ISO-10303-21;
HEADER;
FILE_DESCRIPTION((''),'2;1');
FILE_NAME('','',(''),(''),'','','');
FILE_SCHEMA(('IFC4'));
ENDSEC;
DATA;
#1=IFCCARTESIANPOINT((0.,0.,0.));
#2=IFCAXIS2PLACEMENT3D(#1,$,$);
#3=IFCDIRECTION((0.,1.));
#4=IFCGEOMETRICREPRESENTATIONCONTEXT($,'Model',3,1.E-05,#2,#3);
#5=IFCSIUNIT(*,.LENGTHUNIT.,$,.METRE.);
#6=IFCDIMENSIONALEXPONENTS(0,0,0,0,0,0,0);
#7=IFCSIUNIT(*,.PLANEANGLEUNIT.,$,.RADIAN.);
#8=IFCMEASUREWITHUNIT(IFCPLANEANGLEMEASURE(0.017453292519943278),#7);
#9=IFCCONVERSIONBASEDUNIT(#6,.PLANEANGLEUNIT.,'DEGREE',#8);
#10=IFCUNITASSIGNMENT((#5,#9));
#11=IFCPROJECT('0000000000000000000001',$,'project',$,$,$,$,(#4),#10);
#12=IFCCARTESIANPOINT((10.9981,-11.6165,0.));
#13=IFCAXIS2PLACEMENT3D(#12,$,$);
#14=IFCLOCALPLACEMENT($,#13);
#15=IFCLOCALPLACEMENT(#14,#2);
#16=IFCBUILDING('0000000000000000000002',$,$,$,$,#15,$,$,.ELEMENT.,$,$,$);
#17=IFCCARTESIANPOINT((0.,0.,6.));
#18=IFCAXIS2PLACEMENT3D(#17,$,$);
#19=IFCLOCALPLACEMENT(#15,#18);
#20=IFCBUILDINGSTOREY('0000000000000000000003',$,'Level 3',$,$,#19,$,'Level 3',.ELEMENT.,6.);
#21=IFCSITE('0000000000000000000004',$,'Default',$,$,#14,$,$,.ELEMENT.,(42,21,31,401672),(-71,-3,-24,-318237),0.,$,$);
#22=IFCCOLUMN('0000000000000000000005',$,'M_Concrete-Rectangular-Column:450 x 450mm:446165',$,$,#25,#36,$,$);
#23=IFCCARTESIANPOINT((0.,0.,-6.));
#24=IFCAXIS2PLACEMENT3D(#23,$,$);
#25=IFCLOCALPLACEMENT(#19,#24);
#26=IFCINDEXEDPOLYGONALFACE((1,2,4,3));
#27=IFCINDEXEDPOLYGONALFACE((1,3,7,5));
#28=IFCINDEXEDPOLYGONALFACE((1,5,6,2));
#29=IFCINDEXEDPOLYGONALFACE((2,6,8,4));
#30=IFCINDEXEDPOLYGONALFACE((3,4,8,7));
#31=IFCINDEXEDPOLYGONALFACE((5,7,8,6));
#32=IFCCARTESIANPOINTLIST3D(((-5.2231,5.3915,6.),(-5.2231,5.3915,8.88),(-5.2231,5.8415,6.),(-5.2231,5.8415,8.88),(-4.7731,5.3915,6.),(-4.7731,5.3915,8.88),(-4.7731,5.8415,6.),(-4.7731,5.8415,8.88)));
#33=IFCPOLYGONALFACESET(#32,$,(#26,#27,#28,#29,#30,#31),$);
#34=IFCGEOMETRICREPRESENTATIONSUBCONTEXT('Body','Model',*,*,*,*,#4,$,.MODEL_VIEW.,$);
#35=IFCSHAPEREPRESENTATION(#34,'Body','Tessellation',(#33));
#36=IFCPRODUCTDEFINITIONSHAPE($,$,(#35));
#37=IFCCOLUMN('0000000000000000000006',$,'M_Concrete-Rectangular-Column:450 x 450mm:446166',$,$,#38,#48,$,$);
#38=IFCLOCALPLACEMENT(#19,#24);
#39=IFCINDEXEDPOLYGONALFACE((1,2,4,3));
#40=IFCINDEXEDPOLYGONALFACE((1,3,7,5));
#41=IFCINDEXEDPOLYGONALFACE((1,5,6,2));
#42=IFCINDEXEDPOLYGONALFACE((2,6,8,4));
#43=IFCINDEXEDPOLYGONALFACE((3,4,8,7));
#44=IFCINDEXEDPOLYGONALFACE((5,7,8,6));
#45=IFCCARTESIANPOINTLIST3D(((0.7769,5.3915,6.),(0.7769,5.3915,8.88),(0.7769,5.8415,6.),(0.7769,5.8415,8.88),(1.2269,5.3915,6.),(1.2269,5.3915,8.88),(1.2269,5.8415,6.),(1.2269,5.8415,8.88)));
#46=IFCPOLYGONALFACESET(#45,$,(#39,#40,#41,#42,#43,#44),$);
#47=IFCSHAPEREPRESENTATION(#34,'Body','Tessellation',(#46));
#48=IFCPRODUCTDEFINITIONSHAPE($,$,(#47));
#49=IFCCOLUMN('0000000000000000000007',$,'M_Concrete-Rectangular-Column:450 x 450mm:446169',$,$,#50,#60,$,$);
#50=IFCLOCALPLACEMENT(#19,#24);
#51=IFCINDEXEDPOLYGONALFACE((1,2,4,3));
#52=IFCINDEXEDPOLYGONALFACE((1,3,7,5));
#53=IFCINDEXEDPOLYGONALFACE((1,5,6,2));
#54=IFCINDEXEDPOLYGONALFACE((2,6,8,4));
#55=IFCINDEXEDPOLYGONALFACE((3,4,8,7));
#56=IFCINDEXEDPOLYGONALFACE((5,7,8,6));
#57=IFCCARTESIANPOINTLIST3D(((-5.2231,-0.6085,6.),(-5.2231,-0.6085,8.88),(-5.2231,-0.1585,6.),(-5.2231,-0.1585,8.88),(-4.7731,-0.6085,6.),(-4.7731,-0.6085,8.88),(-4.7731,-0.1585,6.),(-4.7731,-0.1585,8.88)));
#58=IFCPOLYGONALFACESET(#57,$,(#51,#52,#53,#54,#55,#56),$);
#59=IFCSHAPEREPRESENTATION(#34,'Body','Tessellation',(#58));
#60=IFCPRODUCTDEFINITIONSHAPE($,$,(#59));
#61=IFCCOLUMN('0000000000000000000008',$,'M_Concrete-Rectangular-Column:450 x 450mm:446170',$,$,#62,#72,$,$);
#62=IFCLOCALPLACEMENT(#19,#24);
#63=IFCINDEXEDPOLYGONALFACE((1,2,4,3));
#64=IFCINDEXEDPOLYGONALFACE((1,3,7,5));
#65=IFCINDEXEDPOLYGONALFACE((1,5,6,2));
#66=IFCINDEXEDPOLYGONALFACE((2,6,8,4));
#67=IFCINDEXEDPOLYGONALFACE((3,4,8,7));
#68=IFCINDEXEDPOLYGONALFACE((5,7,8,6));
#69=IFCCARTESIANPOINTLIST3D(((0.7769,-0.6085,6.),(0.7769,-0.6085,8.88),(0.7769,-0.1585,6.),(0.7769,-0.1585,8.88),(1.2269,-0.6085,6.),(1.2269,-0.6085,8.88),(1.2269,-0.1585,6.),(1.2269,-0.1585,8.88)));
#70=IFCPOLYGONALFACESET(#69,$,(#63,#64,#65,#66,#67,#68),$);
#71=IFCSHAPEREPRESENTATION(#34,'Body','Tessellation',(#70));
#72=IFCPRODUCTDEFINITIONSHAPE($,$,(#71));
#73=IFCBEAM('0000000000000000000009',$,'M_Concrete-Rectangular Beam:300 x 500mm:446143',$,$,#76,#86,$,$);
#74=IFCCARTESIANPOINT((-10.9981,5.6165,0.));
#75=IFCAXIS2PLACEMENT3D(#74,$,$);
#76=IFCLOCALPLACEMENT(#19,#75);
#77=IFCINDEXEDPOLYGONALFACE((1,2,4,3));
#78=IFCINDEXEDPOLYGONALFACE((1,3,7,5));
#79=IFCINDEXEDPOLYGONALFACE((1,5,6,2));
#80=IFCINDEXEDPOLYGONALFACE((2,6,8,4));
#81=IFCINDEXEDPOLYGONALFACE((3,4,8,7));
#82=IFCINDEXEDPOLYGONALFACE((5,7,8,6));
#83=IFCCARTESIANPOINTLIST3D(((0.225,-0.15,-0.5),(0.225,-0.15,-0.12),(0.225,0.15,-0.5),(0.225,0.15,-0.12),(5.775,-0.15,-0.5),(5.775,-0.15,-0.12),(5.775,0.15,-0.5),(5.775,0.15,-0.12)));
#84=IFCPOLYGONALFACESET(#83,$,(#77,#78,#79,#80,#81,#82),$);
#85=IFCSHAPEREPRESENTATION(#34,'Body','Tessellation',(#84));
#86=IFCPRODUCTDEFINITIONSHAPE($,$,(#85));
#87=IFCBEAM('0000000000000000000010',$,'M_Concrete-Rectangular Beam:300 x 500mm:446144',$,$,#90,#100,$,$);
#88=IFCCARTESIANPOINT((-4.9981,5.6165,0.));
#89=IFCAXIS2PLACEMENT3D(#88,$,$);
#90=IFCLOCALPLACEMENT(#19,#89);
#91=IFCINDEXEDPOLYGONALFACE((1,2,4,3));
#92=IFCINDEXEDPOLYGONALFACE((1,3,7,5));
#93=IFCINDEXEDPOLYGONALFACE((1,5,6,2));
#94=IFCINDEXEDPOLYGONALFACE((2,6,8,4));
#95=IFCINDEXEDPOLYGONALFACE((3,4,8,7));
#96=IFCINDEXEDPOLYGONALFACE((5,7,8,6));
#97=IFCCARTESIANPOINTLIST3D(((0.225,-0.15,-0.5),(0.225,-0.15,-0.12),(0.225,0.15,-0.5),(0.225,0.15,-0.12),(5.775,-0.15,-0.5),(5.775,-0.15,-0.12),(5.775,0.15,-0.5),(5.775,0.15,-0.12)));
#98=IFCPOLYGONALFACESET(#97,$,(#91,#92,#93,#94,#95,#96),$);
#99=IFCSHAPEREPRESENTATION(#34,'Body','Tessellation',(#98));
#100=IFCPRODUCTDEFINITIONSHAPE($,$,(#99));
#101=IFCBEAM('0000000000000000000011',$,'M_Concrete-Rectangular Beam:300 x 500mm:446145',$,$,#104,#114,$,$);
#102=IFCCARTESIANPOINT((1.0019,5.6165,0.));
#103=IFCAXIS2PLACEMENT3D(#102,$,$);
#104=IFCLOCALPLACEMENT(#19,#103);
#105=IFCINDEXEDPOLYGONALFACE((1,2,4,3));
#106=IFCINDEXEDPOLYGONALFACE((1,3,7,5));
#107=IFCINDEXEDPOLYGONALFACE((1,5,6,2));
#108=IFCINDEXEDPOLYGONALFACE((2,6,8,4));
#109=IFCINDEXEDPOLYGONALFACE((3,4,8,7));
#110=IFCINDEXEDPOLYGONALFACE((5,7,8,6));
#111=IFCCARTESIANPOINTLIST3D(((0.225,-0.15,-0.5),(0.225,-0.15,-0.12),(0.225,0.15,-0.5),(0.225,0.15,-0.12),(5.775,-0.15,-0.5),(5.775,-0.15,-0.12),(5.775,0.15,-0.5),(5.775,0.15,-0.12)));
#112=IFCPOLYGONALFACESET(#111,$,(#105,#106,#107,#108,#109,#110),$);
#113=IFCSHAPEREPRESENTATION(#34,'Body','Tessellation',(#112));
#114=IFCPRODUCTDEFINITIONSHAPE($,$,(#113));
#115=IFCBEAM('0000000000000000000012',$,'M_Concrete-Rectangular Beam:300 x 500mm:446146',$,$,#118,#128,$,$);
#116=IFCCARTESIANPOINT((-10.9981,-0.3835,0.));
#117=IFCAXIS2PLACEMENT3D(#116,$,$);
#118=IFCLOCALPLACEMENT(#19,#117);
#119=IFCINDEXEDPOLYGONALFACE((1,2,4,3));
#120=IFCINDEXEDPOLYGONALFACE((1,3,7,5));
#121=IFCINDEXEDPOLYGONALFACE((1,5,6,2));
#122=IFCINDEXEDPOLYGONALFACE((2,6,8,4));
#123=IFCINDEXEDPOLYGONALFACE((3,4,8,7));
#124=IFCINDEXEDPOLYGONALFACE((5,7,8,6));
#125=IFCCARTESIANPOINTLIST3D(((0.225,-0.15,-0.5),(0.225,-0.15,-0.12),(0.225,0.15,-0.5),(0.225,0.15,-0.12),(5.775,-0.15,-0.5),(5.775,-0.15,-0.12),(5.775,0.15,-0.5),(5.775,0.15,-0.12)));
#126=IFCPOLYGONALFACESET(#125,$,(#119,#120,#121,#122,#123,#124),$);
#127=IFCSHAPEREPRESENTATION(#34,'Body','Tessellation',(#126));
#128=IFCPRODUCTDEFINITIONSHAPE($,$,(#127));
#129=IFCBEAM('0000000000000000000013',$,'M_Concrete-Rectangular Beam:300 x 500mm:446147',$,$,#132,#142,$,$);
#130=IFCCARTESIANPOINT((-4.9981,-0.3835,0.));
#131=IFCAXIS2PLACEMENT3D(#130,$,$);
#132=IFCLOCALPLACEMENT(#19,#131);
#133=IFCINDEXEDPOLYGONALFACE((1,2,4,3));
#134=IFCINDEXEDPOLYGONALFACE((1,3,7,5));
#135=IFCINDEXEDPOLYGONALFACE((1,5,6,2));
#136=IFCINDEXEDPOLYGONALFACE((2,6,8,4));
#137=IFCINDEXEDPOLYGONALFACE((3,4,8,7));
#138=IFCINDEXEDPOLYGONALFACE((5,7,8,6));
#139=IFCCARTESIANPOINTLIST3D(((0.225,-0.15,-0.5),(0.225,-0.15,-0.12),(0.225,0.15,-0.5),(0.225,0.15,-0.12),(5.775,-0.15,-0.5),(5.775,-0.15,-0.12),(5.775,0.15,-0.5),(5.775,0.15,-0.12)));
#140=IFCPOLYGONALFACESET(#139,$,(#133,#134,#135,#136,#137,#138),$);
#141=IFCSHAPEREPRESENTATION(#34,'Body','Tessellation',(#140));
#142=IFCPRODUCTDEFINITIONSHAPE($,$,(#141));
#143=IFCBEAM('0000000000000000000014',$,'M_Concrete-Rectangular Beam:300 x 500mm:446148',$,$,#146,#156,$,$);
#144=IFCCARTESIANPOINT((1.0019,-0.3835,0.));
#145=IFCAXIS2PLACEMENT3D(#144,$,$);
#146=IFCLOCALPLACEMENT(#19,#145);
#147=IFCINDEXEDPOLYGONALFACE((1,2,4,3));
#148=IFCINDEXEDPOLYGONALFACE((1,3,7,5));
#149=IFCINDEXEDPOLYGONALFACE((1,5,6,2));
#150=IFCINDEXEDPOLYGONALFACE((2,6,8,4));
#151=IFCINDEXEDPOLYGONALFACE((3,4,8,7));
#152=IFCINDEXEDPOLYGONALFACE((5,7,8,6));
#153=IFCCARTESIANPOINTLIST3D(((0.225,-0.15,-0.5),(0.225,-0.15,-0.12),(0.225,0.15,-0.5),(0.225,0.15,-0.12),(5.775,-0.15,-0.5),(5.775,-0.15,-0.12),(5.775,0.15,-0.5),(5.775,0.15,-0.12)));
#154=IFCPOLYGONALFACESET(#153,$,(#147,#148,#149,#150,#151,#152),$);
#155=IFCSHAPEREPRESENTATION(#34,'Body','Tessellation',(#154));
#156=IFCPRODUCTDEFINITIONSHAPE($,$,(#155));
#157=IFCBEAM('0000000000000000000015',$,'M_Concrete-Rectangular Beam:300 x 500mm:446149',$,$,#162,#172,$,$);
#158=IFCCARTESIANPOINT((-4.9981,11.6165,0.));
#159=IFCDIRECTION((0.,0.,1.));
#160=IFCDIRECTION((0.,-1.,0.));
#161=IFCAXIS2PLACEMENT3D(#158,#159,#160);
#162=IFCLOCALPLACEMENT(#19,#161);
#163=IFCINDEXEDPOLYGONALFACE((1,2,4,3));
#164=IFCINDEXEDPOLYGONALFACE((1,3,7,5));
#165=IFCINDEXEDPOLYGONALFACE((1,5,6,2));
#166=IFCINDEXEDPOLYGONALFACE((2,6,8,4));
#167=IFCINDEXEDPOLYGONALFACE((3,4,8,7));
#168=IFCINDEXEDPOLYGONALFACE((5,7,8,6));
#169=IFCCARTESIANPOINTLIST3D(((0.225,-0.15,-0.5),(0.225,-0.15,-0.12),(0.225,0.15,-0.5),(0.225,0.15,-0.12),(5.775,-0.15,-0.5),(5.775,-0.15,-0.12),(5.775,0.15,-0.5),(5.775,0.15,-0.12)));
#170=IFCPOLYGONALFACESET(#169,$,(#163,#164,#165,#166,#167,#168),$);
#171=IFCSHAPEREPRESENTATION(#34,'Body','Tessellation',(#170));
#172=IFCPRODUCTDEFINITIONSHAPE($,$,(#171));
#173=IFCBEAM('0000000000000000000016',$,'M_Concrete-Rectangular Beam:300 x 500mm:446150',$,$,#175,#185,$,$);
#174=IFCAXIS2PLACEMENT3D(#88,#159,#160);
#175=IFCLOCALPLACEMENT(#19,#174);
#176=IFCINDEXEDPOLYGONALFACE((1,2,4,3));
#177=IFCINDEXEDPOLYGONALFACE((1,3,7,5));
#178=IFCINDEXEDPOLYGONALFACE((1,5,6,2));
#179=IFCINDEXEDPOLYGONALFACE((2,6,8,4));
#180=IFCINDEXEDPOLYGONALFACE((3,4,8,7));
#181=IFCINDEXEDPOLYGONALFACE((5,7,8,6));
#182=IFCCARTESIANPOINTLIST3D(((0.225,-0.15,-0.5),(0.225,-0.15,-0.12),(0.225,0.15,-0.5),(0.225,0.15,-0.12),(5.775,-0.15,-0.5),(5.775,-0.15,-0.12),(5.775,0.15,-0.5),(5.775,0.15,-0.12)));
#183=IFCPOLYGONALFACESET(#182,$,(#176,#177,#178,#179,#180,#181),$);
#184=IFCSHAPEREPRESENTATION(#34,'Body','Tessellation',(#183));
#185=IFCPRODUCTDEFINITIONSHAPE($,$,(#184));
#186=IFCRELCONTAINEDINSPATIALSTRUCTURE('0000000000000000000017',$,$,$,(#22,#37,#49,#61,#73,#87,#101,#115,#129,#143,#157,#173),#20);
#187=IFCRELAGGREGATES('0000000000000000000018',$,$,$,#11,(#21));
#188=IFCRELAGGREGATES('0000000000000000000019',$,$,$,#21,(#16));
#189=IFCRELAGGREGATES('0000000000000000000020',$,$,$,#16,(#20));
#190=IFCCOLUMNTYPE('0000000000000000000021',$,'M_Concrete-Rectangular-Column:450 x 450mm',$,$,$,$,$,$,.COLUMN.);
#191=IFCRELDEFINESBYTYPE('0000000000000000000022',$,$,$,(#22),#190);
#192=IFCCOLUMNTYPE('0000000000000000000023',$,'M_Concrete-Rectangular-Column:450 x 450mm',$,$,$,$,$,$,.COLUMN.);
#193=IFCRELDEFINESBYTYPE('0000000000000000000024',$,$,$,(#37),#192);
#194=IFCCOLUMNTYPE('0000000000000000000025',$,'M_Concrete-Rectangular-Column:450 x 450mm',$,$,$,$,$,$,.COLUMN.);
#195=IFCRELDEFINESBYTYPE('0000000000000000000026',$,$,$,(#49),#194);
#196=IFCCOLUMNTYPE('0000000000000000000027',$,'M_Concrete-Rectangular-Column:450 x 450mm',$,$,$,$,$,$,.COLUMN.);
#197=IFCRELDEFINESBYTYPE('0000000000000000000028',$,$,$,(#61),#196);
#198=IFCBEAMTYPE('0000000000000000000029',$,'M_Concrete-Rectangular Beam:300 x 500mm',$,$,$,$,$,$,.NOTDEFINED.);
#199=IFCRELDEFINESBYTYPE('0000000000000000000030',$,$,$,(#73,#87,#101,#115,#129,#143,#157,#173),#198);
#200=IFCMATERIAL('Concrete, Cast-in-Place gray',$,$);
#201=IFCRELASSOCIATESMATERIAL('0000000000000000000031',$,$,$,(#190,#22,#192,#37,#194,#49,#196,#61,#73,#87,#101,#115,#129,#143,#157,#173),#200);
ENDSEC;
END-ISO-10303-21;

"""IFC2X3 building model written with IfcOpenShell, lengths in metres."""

from ifc_helpers import new_model, entity, si_unit, converted_unit, direction, frame, frame_2d, origin, place, context, subcontext, project, spatial, rectangle, extrude, source, transform, mapped, material, type_object, type_shapes, element, save


model = new_model("IFC2X3")

# Units and contexts
model_context = context("Model", 3, precision=1e-05, world=origin(), true_north=direction((0.0, 1.0)))
body_context = subcontext(model_context, "Body", "Model", "MODEL_VIEW")
ifc_project = project(units=[si_unit("LENGTHUNIT", "METRE"), converted_unit("PLANEANGLEUNIT", "DEGREE", entity("IfcPlaneAngleMeasure", 0.017453292519943278), si_unit("PLANEANGLEUNIT", "RADIAN"), dimensions=[0, 0, 0, 0, 0, 0, 0])], contexts=[model_context])

# Site, building, storey
site_placement = place(None, frame((10.9981, -11.6165, 0.0)))
site = spatial("IfcSite", under=ifc_project, at=site_placement, Name="Default", CompositionType="ELEMENT", RefLatitude=(42, 21, 31, 401672), RefLongitude=(-71, -3, -24, -318237), RefElevation=0.0)
building_placement = place(site_placement, origin())
building = spatial("IfcBuilding", under=site, at=building_placement, CompositionType="ELEMENT")
storey_placement = place(building_placement, frame((0.0, 0.0, 6.0)))
storey = spatial("IfcBuildingStorey", under=building, at=storey_placement, Name="Level 3", LongName="Level 3", CompositionType="ELEMENT", Elevation=6.0)

# Columns
ifc_material_1 = material(Name="Concrete, Cast-in-Place gray")
column_type_1 = type_object("IfcColumnType", Name="M_Concrete-Rectangular-Column:450 x 450mm", PredefinedType="COLUMN", material=ifc_material_1)
shared_shape_1 = source(origin(), body_context, "Body", "SweptSolid", [
    extrude(rectangle(XDim=0.45, YDim=0.45, at=frame_2d((0.0, 0.0), x_axis=(1.0, 0.0))), frame((-4.9981, 5.6165, 6.0), z_axis=(0.0, 0.0, 1.0), x_axis=(-1.0, 0.0, 0.0)), (0.0, 0.0, 1.0), 2.88),
])
type_shapes(column_type_1, [shared_shape_1])
column_1_placement = place(storey_placement, frame((0.0, 0.0, -6.0)))
element("IfcColumn", 1, at=column_1_placement, inside=storey, type_object=column_type_1, material=ifc_material_1, Name="M_Concrete-Rectangular-Column:450 x 450mm:446165", context=body_context, shape_type="MappedRepresentation", body=[
    mapped(shared_shape_1, transform((0.0, 0.0, 0.0), scale=1.0)),
])
column_type_2 = type_object("IfcColumnType", Name="M_Concrete-Rectangular-Column:450 x 450mm", PredefinedType="COLUMN", material=ifc_material_1)
shared_shape_2 = source(origin(), body_context, "Body", "SweptSolid", [
    extrude(rectangle(XDim=0.45, YDim=0.45, at=frame_2d((0.0, 0.0), x_axis=(1.0, 0.0))), frame((1.0019, 5.6165, 6.0), z_axis=(0.0, 0.0, 1.0), x_axis=(-1.0, 0.0, 0.0)), (0.0, 0.0, 1.0), 2.88),
])
type_shapes(column_type_2, [shared_shape_2])
column_2_placement = place(storey_placement, frame((0.0, 0.0, -6.0)))
element("IfcColumn", 2, at=column_2_placement, inside=storey, type_object=column_type_2, material=ifc_material_1, Name="M_Concrete-Rectangular-Column:450 x 450mm:446166", context=body_context, shape_type="MappedRepresentation", body=[
    mapped(shared_shape_2, transform((0.0, 0.0, 0.0), scale=1.0)),
])
column_type_3 = type_object("IfcColumnType", Name="M_Concrete-Rectangular-Column:450 x 450mm", PredefinedType="COLUMN", material=ifc_material_1)
shared_shape_3 = source(origin(), body_context, "Body", "SweptSolid", [
    extrude(rectangle(XDim=0.45, YDim=0.45, at=frame_2d((0.0, 0.0), x_axis=(1.0, 0.0))), frame((-4.9981, -0.3835, 6.0), z_axis=(0.0, 0.0, 1.0), x_axis=(-1.0, 0.0, 0.0)), (0.0, 0.0, 1.0), 2.88),
])
type_shapes(column_type_3, [shared_shape_3])
column_3_placement = place(storey_placement, frame((0.0, 0.0, -6.0)))
element("IfcColumn", 3, at=column_3_placement, inside=storey, type_object=column_type_3, material=ifc_material_1, Name="M_Concrete-Rectangular-Column:450 x 450mm:446169", context=body_context, shape_type="MappedRepresentation", body=[
    mapped(shared_shape_3, transform((0.0, 0.0, 0.0), scale=1.0)),
])
column_type_4 = type_object("IfcColumnType", Name="M_Concrete-Rectangular-Column:450 x 450mm", PredefinedType="COLUMN", material=ifc_material_1)
shared_shape_4 = source(origin(), body_context, "Body", "SweptSolid", [
    extrude(rectangle(XDim=0.45, YDim=0.45, at=frame_2d((0.0, 0.0), x_axis=(1.0, 0.0))), frame((1.0019, -0.3835, 6.0), z_axis=(0.0, 0.0, 1.0), x_axis=(-1.0, 0.0, 0.0)), (0.0, 0.0, 1.0), 2.88),
])
type_shapes(column_type_4, [shared_shape_4])
column_4_placement = place(storey_placement, frame((0.0, 0.0, -6.0)))
element("IfcColumn", 4, at=column_4_placement, inside=storey, type_object=column_type_4, material=ifc_material_1, Name="M_Concrete-Rectangular-Column:450 x 450mm:446170", context=body_context, shape_type="MappedRepresentation", body=[
    mapped(shared_shape_4, transform((0.0, 0.0, 0.0), scale=1.0)),
])

# Beams
beam_type = type_object("IfcBeamType", Name="M_Concrete-Rectangular Beam:300 x 500mm", PredefinedType="NOTDEFINED")
beam_1_placement = place(storey_placement, frame((-10.9981, 5.6165, 0.0)))
element("IfcBeam", 5, at=beam_1_placement, inside=storey, type_object=beam_type, material=ifc_material_1, Name="M_Concrete-Rectangular Beam:300 x 500mm:446143", context=body_context, shape_type="SweptSolid", body=[
    extrude(rectangle(XDim=0.38, YDim=0.3, at=frame_2d((0.0, 0.0), x_axis=(1.0, 0.0))), frame((0.225, 0.0, -0.31), z_axis=(1.0, 0.0, 0.0), x_axis=(0.0, 0.0, -1.0)), (0.0, 0.0, 1.0), 5.55),
])
beam_2_placement = place(storey_placement, frame((-4.9981, 5.6165, 0.0)))
element("IfcBeam", 6, at=beam_2_placement, inside=storey, type_object=beam_type, material=ifc_material_1, Name="M_Concrete-Rectangular Beam:300 x 500mm:446144", context=body_context, shape_type="SweptSolid", body=[
    extrude(rectangle(XDim=0.38, YDim=0.3, at=frame_2d((0.0, 0.0), x_axis=(1.0, 0.0))), frame((0.225, 0.0, -0.31), z_axis=(1.0, 0.0, 0.0), x_axis=(0.0, 0.0, -1.0)), (0.0, 0.0, 1.0), 5.55),
])
beam_3_placement = place(storey_placement, frame((1.0019, 5.6165, 0.0)))
element("IfcBeam", 7, at=beam_3_placement, inside=storey, type_object=beam_type, material=ifc_material_1, Name="M_Concrete-Rectangular Beam:300 x 500mm:446145", context=body_context, shape_type="SweptSolid", body=[
    extrude(rectangle(XDim=0.38, YDim=0.3, at=frame_2d((0.0, 0.0), x_axis=(1.0, 0.0))), frame((0.225, 0.0, -0.31), z_axis=(1.0, 0.0, 0.0), x_axis=(0.0, 0.0, -1.0)), (0.0, 0.0, 1.0), 5.55),
])
beam_4_placement = place(storey_placement, frame((-10.9981, -0.3835, 0.0)))
element("IfcBeam", 8, at=beam_4_placement, inside=storey, type_object=beam_type, material=ifc_material_1, Name="M_Concrete-Rectangular Beam:300 x 500mm:446146", context=body_context, shape_type="SweptSolid", body=[
    extrude(rectangle(XDim=0.38, YDim=0.3, at=frame_2d((0.0, 0.0), x_axis=(1.0, 0.0))), frame((0.225, 0.0, -0.31), z_axis=(1.0, 0.0, 0.0), x_axis=(0.0, 0.0, -1.0)), (0.0, 0.0, 1.0), 5.55),
])
beam_5_placement = place(storey_placement, frame((-4.9981, -0.3835, 0.0)))
element("IfcBeam", 9, at=beam_5_placement, inside=storey, type_object=beam_type, material=ifc_material_1, Name="M_Concrete-Rectangular Beam:300 x 500mm:446147", context=body_context, shape_type="SweptSolid", body=[
    extrude(rectangle(XDim=0.38, YDim=0.3, at=frame_2d((0.0, 0.0), x_axis=(1.0, 0.0))), frame((0.225, 0.0, -0.31), z_axis=(1.0, 0.0, 0.0), x_axis=(0.0, 0.0, -1.0)), (0.0, 0.0, 1.0), 5.55),
])
beam_6_placement = place(storey_placement, frame((1.0019, -0.3835, 0.0)))
element("IfcBeam", 10, at=beam_6_placement, inside=storey, type_object=beam_type, material=ifc_material_1, Name="M_Concrete-Rectangular Beam:300 x 500mm:446148", context=body_context, shape_type="SweptSolid", body=[
    extrude(rectangle(XDim=0.38, YDim=0.3, at=frame_2d((0.0, 0.0), x_axis=(1.0, 0.0))), frame((0.225, 0.0, -0.31), z_axis=(1.0, 0.0, 0.0), x_axis=(0.0, 0.0, -1.0)), (0.0, 0.0, 1.0), 5.55),
])
beam_7_placement = place(storey_placement, frame((-4.9981, 11.6165, 0.0), z_axis=(0.0, 0.0, 1.0), x_axis=(0.0, -1.0, 0.0)))
element("IfcBeam", 11, at=beam_7_placement, inside=storey, type_object=beam_type, material=ifc_material_1, Name="M_Concrete-Rectangular Beam:300 x 500mm:446149", context=body_context, shape_type="SweptSolid", body=[
    extrude(rectangle(XDim=0.38, YDim=0.3, at=frame_2d((0.0, 0.0), x_axis=(1.0, 0.0))), frame((0.225, 0.0, -0.31), z_axis=(1.0, 0.0, 0.0), x_axis=(0.0, 0.0, -1.0)), (0.0, 0.0, 1.0), 5.55),
])
beam_8_placement = place(storey_placement, frame((-4.9981, 5.6165, 0.0), z_axis=(0.0, 0.0, 1.0), x_axis=(0.0, -1.0, 0.0)))
element("IfcBeam", 12, at=beam_8_placement, inside=storey, type_object=beam_type, material=ifc_material_1, Name="M_Concrete-Rectangular Beam:300 x 500mm:446150", context=body_context, shape_type="SweptSolid", body=[
    extrude(rectangle(XDim=0.38, YDim=0.3, at=frame_2d((0.0, 0.0), x_axis=(1.0, 0.0))), frame((0.225, 0.0, -0.31), z_axis=(1.0, 0.0, 0.0), x_axis=(0.0, 0.0, -1.0)), (0.0, 0.0, 1.0), 5.55),
])

save(model, "model.ifc")
